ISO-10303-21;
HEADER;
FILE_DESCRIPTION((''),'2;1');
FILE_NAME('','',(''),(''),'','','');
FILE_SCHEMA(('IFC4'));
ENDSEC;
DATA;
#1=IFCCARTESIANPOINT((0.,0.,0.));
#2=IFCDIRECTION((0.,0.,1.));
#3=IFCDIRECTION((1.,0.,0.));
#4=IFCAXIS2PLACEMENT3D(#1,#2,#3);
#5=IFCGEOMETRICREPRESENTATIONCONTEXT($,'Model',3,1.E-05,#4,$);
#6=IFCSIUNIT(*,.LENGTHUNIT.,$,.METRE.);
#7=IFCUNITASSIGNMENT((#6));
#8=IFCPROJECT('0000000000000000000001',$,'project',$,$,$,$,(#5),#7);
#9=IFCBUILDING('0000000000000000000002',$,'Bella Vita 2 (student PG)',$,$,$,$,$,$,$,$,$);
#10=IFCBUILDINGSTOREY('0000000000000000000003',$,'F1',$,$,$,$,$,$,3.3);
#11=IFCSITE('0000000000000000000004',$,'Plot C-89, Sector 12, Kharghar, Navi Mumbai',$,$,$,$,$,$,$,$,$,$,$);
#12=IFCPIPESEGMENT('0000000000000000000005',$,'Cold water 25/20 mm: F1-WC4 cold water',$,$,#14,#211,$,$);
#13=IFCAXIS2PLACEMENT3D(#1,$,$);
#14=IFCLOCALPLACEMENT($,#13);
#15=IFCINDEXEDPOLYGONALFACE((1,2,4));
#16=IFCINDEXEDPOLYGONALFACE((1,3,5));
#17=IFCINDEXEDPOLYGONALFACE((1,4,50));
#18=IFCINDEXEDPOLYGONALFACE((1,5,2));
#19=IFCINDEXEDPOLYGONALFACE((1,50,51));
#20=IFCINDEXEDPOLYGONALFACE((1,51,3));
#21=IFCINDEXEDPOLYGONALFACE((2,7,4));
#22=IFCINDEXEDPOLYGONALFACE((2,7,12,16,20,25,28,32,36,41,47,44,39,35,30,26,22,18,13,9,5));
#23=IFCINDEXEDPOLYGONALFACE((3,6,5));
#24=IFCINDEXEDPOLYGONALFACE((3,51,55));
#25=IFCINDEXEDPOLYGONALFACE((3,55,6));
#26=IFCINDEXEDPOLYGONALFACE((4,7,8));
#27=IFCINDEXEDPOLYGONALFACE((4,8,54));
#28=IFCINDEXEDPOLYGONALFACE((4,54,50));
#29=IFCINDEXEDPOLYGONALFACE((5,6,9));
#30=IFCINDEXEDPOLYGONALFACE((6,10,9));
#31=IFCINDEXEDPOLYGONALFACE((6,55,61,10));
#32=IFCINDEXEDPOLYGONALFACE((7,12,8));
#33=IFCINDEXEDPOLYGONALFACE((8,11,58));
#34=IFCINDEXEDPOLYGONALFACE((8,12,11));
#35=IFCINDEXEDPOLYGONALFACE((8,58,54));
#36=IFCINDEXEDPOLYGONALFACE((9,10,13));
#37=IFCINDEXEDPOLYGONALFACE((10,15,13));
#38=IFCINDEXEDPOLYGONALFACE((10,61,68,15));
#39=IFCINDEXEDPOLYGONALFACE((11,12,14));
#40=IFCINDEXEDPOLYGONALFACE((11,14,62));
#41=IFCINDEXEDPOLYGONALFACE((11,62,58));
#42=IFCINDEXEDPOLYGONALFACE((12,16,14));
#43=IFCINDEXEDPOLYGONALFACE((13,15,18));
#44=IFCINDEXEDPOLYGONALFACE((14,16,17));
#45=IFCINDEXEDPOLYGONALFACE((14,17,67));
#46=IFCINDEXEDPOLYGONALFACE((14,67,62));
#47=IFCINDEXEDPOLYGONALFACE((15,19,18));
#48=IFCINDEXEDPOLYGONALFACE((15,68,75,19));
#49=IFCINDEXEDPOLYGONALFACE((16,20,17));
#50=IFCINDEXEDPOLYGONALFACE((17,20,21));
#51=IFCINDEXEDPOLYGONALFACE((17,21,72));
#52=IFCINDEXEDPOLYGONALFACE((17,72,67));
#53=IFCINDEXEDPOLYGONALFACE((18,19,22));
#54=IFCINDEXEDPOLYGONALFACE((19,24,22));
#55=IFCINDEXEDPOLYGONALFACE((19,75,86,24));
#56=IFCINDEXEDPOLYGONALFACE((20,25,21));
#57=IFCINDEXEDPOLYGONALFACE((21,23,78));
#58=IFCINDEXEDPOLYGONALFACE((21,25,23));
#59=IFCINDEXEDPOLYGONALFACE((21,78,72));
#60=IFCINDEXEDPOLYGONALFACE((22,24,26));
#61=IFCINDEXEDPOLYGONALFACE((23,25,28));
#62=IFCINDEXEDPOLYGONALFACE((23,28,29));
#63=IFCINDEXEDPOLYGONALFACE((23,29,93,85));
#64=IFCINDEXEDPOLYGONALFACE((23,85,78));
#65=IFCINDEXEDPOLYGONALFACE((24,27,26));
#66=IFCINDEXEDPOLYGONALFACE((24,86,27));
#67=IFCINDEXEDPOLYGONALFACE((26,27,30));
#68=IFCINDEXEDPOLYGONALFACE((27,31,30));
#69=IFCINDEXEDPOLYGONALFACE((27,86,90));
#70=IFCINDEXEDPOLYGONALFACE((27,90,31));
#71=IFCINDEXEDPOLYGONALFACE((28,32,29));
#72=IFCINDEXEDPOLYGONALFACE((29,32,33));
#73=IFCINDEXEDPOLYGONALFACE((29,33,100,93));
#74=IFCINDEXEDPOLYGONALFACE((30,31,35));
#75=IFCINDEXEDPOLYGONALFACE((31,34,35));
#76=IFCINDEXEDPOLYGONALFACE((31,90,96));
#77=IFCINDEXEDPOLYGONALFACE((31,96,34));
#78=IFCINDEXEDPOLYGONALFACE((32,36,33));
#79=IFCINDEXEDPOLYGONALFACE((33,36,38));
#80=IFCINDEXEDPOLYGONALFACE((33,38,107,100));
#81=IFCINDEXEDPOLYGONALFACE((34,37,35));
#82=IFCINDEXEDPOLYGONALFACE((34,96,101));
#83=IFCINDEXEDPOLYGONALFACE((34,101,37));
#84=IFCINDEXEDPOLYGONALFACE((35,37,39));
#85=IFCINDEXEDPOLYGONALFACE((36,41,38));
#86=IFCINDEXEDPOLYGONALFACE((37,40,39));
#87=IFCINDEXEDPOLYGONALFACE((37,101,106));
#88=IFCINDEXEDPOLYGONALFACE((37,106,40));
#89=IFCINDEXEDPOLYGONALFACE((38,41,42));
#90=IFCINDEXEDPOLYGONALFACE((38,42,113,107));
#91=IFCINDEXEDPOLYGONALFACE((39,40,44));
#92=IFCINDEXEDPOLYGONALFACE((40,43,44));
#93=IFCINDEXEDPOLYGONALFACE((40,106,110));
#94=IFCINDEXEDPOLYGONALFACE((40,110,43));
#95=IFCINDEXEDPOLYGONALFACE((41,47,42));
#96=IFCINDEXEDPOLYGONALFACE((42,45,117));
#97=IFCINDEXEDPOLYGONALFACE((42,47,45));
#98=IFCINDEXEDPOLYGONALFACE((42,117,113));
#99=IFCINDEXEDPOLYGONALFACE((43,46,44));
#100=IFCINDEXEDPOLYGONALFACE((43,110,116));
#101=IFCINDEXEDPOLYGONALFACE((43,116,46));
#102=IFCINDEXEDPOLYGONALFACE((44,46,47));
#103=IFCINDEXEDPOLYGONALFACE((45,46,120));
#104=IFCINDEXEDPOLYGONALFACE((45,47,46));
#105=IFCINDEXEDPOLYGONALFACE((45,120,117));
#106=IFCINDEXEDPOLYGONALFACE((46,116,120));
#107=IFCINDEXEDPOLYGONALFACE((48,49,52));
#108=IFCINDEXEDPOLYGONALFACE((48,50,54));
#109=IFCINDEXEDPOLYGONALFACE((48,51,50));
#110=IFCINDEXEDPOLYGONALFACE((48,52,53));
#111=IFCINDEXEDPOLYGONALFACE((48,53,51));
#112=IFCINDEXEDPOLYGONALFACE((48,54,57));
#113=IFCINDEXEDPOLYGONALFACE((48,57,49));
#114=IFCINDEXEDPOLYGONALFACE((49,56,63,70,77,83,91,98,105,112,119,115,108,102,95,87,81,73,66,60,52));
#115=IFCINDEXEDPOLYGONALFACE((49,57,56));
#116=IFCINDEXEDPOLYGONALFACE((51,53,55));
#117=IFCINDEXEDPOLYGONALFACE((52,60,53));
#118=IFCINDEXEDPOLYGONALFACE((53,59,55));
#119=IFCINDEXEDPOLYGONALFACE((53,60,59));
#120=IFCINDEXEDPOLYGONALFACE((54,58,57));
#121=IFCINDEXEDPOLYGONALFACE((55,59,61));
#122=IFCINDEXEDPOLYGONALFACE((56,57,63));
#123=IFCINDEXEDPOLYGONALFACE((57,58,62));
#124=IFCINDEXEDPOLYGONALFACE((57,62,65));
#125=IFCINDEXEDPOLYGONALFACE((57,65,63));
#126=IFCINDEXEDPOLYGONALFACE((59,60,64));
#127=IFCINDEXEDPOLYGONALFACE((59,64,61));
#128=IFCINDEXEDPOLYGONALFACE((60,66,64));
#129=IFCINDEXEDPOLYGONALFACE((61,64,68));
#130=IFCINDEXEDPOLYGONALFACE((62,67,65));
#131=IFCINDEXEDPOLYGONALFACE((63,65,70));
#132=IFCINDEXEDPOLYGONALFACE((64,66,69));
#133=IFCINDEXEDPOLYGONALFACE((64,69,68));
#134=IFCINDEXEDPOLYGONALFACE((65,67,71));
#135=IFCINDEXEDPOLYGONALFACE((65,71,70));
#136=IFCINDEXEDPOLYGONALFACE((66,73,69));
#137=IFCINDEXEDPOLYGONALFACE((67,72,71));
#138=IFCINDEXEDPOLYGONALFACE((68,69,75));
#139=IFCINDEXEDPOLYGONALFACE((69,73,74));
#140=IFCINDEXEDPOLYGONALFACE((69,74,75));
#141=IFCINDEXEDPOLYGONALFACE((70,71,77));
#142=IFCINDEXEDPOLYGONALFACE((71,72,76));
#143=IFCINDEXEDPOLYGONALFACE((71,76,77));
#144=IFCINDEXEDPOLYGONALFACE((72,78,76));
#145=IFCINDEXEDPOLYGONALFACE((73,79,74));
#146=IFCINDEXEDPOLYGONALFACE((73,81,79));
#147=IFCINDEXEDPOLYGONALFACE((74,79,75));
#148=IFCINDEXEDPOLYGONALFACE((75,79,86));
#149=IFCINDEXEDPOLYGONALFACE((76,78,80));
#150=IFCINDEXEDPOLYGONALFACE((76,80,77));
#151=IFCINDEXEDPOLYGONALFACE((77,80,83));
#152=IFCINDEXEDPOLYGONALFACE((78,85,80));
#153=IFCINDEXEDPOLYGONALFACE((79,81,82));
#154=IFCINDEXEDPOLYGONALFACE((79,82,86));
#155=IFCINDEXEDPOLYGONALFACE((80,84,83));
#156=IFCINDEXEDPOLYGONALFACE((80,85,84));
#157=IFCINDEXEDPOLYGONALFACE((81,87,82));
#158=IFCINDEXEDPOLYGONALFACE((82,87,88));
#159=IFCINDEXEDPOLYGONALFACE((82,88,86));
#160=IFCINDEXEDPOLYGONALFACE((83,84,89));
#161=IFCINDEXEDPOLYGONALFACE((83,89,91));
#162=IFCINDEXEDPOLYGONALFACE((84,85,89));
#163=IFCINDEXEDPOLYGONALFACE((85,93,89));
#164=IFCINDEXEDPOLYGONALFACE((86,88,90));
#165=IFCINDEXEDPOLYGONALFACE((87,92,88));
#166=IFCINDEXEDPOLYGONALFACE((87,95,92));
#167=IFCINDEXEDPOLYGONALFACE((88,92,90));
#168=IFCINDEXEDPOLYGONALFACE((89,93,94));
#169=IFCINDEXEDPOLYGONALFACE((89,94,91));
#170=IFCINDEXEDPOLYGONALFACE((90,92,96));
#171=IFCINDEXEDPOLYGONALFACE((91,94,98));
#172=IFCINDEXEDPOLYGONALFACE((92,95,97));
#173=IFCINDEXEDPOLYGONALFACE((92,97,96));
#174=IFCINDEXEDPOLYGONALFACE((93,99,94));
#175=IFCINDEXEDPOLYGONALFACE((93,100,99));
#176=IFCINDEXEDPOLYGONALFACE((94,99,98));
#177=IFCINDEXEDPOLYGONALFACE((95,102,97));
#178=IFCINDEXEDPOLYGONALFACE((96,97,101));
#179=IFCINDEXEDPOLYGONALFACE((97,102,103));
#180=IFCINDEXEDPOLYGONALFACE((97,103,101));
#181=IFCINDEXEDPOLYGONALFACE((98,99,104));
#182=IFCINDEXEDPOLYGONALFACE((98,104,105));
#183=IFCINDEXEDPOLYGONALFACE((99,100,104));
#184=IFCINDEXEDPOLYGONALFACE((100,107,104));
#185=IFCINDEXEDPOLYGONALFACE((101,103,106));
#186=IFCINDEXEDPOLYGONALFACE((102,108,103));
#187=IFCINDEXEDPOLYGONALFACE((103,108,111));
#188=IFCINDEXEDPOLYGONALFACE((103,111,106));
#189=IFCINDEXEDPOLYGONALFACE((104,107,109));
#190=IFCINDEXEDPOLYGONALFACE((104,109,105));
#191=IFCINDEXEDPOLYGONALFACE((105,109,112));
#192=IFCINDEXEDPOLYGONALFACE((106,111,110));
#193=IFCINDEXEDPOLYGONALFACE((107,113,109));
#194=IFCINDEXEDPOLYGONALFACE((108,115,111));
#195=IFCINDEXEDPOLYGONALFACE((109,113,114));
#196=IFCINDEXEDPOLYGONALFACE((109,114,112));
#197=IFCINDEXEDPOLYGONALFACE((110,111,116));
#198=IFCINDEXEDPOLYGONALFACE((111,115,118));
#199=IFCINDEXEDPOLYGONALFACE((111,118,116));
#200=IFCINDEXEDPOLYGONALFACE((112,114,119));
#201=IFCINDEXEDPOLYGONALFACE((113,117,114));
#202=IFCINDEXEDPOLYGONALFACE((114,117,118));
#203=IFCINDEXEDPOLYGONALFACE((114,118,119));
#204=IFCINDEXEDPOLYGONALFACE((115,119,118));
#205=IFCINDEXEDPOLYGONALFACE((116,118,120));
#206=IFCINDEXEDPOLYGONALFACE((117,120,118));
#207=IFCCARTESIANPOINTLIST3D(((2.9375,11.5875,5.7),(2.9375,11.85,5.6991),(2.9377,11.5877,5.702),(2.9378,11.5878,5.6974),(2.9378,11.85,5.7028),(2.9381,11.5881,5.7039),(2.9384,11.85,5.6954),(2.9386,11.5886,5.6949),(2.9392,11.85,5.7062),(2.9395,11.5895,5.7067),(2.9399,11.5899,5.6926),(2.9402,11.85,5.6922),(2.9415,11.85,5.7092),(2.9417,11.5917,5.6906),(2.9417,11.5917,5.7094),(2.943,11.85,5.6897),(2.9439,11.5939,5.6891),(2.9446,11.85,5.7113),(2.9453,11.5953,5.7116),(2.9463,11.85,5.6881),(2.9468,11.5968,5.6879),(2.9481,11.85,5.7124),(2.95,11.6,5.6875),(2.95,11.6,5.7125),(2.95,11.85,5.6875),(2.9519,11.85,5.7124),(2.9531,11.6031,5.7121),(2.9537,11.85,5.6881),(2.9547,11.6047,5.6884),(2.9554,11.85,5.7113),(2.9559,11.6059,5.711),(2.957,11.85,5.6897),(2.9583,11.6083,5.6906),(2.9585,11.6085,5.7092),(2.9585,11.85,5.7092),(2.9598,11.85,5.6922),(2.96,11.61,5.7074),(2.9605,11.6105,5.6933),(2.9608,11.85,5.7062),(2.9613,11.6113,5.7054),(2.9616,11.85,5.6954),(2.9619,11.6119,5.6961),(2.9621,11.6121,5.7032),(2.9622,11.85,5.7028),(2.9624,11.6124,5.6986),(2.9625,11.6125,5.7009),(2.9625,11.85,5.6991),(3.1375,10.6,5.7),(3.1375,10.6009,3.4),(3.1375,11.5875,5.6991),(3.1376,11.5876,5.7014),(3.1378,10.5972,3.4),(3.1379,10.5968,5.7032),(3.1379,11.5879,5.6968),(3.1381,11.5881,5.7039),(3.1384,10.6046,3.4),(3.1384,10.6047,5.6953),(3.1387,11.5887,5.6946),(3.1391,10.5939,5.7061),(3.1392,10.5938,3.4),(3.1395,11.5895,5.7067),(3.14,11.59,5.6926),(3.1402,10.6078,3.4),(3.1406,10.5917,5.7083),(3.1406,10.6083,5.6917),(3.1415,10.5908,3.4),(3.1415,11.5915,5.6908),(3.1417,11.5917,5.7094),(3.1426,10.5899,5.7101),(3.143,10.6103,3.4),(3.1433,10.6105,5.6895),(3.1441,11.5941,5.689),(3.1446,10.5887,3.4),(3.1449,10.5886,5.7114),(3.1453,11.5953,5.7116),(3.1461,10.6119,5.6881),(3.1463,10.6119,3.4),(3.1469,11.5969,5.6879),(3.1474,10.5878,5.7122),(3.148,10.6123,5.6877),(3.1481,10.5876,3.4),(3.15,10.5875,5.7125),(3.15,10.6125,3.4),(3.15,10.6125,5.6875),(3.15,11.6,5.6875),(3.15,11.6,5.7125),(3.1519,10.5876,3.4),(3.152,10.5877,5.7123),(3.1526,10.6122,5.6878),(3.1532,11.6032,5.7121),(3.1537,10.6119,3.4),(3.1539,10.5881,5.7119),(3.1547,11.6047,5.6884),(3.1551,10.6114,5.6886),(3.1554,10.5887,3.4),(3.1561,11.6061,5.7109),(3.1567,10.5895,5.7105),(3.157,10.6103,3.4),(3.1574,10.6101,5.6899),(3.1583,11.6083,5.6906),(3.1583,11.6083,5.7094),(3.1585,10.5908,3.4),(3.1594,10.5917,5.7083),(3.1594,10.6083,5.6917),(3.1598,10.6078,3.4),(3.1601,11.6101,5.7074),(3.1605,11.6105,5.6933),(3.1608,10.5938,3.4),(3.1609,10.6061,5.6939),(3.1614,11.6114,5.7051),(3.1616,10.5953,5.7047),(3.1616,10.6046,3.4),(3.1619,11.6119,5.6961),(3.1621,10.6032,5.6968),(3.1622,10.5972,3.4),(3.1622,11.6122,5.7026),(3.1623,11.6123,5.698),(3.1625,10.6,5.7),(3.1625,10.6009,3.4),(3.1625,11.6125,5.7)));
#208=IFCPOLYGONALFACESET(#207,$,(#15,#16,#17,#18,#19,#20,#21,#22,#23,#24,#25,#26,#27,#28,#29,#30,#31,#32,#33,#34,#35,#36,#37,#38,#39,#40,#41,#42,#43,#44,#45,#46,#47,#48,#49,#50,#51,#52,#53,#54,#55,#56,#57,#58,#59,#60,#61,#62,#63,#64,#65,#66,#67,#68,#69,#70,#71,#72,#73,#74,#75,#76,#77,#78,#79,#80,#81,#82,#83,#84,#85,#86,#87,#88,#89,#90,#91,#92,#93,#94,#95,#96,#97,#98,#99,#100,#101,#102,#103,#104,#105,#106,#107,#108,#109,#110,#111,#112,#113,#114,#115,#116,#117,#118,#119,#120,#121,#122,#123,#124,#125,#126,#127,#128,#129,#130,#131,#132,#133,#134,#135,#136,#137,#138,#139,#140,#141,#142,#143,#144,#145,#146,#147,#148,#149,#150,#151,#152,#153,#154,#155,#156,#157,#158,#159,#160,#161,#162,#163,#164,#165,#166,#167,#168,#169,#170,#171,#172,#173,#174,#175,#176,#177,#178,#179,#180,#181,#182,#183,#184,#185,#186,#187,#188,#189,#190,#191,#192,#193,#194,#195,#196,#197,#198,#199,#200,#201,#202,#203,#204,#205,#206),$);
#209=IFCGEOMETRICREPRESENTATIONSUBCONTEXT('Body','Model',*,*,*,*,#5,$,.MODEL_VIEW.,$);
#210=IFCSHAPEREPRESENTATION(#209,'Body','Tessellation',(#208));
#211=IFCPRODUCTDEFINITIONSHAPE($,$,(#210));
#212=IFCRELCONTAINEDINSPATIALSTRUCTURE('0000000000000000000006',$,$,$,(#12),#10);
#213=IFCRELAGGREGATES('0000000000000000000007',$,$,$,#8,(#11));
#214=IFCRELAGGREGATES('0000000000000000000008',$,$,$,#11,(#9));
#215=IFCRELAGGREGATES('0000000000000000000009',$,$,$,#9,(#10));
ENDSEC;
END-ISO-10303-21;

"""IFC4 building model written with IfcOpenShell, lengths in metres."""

from ifc_helpers import new_model, entity, si_unit, origin, origin_with_axes, place, context, subcontext, project, spatial, element, save


model = new_model("IFC4")

# Units and contexts
model_context = context("Model", 3, precision=1e-05, world=origin_with_axes())
body_context = subcontext(model_context, "Body", "Model", "MODEL_VIEW")
ifc_project = project(units=[si_unit("LENGTHUNIT", "METRE")], contexts=[model_context])

# Site, building, storey
site = spatial("IfcSite", under=ifc_project, Name="Plot C-89, Sector 12, Kharghar, Navi Mumbai")
building = spatial("IfcBuilding", under=site, Name="Bella Vita 2 (student PG)")
storey = spatial("IfcBuildingStorey", under=building, Name="F1", Elevation=3.3)

# Pipe segment
pipe_segment_1_placement = place(None, origin())
element("IfcPipeSegment", 1, at=pipe_segment_1_placement, inside=storey, Name="Cold water 25/20 mm: F1-WC4 cold water", context=body_context, shape_type="AdvancedSweptSolid", body=[
    entity("IfcSweptDiskSolid", entity("IfcPolyline", [entity("IfcCartesianPoint", [2.95, 11.85, 5.7]), entity("IfcCartesianPoint", [2.95, 11.6, 5.7]), entity("IfcCartesianPoint", [3.15, 11.6, 5.7]), entity("IfcCartesianPoint", [3.15, 10.6, 5.7]), entity("IfcCartesianPoint", [3.15, 10.6, 3.4])]), 0.0125),
])

save(model, "model.ifc")
